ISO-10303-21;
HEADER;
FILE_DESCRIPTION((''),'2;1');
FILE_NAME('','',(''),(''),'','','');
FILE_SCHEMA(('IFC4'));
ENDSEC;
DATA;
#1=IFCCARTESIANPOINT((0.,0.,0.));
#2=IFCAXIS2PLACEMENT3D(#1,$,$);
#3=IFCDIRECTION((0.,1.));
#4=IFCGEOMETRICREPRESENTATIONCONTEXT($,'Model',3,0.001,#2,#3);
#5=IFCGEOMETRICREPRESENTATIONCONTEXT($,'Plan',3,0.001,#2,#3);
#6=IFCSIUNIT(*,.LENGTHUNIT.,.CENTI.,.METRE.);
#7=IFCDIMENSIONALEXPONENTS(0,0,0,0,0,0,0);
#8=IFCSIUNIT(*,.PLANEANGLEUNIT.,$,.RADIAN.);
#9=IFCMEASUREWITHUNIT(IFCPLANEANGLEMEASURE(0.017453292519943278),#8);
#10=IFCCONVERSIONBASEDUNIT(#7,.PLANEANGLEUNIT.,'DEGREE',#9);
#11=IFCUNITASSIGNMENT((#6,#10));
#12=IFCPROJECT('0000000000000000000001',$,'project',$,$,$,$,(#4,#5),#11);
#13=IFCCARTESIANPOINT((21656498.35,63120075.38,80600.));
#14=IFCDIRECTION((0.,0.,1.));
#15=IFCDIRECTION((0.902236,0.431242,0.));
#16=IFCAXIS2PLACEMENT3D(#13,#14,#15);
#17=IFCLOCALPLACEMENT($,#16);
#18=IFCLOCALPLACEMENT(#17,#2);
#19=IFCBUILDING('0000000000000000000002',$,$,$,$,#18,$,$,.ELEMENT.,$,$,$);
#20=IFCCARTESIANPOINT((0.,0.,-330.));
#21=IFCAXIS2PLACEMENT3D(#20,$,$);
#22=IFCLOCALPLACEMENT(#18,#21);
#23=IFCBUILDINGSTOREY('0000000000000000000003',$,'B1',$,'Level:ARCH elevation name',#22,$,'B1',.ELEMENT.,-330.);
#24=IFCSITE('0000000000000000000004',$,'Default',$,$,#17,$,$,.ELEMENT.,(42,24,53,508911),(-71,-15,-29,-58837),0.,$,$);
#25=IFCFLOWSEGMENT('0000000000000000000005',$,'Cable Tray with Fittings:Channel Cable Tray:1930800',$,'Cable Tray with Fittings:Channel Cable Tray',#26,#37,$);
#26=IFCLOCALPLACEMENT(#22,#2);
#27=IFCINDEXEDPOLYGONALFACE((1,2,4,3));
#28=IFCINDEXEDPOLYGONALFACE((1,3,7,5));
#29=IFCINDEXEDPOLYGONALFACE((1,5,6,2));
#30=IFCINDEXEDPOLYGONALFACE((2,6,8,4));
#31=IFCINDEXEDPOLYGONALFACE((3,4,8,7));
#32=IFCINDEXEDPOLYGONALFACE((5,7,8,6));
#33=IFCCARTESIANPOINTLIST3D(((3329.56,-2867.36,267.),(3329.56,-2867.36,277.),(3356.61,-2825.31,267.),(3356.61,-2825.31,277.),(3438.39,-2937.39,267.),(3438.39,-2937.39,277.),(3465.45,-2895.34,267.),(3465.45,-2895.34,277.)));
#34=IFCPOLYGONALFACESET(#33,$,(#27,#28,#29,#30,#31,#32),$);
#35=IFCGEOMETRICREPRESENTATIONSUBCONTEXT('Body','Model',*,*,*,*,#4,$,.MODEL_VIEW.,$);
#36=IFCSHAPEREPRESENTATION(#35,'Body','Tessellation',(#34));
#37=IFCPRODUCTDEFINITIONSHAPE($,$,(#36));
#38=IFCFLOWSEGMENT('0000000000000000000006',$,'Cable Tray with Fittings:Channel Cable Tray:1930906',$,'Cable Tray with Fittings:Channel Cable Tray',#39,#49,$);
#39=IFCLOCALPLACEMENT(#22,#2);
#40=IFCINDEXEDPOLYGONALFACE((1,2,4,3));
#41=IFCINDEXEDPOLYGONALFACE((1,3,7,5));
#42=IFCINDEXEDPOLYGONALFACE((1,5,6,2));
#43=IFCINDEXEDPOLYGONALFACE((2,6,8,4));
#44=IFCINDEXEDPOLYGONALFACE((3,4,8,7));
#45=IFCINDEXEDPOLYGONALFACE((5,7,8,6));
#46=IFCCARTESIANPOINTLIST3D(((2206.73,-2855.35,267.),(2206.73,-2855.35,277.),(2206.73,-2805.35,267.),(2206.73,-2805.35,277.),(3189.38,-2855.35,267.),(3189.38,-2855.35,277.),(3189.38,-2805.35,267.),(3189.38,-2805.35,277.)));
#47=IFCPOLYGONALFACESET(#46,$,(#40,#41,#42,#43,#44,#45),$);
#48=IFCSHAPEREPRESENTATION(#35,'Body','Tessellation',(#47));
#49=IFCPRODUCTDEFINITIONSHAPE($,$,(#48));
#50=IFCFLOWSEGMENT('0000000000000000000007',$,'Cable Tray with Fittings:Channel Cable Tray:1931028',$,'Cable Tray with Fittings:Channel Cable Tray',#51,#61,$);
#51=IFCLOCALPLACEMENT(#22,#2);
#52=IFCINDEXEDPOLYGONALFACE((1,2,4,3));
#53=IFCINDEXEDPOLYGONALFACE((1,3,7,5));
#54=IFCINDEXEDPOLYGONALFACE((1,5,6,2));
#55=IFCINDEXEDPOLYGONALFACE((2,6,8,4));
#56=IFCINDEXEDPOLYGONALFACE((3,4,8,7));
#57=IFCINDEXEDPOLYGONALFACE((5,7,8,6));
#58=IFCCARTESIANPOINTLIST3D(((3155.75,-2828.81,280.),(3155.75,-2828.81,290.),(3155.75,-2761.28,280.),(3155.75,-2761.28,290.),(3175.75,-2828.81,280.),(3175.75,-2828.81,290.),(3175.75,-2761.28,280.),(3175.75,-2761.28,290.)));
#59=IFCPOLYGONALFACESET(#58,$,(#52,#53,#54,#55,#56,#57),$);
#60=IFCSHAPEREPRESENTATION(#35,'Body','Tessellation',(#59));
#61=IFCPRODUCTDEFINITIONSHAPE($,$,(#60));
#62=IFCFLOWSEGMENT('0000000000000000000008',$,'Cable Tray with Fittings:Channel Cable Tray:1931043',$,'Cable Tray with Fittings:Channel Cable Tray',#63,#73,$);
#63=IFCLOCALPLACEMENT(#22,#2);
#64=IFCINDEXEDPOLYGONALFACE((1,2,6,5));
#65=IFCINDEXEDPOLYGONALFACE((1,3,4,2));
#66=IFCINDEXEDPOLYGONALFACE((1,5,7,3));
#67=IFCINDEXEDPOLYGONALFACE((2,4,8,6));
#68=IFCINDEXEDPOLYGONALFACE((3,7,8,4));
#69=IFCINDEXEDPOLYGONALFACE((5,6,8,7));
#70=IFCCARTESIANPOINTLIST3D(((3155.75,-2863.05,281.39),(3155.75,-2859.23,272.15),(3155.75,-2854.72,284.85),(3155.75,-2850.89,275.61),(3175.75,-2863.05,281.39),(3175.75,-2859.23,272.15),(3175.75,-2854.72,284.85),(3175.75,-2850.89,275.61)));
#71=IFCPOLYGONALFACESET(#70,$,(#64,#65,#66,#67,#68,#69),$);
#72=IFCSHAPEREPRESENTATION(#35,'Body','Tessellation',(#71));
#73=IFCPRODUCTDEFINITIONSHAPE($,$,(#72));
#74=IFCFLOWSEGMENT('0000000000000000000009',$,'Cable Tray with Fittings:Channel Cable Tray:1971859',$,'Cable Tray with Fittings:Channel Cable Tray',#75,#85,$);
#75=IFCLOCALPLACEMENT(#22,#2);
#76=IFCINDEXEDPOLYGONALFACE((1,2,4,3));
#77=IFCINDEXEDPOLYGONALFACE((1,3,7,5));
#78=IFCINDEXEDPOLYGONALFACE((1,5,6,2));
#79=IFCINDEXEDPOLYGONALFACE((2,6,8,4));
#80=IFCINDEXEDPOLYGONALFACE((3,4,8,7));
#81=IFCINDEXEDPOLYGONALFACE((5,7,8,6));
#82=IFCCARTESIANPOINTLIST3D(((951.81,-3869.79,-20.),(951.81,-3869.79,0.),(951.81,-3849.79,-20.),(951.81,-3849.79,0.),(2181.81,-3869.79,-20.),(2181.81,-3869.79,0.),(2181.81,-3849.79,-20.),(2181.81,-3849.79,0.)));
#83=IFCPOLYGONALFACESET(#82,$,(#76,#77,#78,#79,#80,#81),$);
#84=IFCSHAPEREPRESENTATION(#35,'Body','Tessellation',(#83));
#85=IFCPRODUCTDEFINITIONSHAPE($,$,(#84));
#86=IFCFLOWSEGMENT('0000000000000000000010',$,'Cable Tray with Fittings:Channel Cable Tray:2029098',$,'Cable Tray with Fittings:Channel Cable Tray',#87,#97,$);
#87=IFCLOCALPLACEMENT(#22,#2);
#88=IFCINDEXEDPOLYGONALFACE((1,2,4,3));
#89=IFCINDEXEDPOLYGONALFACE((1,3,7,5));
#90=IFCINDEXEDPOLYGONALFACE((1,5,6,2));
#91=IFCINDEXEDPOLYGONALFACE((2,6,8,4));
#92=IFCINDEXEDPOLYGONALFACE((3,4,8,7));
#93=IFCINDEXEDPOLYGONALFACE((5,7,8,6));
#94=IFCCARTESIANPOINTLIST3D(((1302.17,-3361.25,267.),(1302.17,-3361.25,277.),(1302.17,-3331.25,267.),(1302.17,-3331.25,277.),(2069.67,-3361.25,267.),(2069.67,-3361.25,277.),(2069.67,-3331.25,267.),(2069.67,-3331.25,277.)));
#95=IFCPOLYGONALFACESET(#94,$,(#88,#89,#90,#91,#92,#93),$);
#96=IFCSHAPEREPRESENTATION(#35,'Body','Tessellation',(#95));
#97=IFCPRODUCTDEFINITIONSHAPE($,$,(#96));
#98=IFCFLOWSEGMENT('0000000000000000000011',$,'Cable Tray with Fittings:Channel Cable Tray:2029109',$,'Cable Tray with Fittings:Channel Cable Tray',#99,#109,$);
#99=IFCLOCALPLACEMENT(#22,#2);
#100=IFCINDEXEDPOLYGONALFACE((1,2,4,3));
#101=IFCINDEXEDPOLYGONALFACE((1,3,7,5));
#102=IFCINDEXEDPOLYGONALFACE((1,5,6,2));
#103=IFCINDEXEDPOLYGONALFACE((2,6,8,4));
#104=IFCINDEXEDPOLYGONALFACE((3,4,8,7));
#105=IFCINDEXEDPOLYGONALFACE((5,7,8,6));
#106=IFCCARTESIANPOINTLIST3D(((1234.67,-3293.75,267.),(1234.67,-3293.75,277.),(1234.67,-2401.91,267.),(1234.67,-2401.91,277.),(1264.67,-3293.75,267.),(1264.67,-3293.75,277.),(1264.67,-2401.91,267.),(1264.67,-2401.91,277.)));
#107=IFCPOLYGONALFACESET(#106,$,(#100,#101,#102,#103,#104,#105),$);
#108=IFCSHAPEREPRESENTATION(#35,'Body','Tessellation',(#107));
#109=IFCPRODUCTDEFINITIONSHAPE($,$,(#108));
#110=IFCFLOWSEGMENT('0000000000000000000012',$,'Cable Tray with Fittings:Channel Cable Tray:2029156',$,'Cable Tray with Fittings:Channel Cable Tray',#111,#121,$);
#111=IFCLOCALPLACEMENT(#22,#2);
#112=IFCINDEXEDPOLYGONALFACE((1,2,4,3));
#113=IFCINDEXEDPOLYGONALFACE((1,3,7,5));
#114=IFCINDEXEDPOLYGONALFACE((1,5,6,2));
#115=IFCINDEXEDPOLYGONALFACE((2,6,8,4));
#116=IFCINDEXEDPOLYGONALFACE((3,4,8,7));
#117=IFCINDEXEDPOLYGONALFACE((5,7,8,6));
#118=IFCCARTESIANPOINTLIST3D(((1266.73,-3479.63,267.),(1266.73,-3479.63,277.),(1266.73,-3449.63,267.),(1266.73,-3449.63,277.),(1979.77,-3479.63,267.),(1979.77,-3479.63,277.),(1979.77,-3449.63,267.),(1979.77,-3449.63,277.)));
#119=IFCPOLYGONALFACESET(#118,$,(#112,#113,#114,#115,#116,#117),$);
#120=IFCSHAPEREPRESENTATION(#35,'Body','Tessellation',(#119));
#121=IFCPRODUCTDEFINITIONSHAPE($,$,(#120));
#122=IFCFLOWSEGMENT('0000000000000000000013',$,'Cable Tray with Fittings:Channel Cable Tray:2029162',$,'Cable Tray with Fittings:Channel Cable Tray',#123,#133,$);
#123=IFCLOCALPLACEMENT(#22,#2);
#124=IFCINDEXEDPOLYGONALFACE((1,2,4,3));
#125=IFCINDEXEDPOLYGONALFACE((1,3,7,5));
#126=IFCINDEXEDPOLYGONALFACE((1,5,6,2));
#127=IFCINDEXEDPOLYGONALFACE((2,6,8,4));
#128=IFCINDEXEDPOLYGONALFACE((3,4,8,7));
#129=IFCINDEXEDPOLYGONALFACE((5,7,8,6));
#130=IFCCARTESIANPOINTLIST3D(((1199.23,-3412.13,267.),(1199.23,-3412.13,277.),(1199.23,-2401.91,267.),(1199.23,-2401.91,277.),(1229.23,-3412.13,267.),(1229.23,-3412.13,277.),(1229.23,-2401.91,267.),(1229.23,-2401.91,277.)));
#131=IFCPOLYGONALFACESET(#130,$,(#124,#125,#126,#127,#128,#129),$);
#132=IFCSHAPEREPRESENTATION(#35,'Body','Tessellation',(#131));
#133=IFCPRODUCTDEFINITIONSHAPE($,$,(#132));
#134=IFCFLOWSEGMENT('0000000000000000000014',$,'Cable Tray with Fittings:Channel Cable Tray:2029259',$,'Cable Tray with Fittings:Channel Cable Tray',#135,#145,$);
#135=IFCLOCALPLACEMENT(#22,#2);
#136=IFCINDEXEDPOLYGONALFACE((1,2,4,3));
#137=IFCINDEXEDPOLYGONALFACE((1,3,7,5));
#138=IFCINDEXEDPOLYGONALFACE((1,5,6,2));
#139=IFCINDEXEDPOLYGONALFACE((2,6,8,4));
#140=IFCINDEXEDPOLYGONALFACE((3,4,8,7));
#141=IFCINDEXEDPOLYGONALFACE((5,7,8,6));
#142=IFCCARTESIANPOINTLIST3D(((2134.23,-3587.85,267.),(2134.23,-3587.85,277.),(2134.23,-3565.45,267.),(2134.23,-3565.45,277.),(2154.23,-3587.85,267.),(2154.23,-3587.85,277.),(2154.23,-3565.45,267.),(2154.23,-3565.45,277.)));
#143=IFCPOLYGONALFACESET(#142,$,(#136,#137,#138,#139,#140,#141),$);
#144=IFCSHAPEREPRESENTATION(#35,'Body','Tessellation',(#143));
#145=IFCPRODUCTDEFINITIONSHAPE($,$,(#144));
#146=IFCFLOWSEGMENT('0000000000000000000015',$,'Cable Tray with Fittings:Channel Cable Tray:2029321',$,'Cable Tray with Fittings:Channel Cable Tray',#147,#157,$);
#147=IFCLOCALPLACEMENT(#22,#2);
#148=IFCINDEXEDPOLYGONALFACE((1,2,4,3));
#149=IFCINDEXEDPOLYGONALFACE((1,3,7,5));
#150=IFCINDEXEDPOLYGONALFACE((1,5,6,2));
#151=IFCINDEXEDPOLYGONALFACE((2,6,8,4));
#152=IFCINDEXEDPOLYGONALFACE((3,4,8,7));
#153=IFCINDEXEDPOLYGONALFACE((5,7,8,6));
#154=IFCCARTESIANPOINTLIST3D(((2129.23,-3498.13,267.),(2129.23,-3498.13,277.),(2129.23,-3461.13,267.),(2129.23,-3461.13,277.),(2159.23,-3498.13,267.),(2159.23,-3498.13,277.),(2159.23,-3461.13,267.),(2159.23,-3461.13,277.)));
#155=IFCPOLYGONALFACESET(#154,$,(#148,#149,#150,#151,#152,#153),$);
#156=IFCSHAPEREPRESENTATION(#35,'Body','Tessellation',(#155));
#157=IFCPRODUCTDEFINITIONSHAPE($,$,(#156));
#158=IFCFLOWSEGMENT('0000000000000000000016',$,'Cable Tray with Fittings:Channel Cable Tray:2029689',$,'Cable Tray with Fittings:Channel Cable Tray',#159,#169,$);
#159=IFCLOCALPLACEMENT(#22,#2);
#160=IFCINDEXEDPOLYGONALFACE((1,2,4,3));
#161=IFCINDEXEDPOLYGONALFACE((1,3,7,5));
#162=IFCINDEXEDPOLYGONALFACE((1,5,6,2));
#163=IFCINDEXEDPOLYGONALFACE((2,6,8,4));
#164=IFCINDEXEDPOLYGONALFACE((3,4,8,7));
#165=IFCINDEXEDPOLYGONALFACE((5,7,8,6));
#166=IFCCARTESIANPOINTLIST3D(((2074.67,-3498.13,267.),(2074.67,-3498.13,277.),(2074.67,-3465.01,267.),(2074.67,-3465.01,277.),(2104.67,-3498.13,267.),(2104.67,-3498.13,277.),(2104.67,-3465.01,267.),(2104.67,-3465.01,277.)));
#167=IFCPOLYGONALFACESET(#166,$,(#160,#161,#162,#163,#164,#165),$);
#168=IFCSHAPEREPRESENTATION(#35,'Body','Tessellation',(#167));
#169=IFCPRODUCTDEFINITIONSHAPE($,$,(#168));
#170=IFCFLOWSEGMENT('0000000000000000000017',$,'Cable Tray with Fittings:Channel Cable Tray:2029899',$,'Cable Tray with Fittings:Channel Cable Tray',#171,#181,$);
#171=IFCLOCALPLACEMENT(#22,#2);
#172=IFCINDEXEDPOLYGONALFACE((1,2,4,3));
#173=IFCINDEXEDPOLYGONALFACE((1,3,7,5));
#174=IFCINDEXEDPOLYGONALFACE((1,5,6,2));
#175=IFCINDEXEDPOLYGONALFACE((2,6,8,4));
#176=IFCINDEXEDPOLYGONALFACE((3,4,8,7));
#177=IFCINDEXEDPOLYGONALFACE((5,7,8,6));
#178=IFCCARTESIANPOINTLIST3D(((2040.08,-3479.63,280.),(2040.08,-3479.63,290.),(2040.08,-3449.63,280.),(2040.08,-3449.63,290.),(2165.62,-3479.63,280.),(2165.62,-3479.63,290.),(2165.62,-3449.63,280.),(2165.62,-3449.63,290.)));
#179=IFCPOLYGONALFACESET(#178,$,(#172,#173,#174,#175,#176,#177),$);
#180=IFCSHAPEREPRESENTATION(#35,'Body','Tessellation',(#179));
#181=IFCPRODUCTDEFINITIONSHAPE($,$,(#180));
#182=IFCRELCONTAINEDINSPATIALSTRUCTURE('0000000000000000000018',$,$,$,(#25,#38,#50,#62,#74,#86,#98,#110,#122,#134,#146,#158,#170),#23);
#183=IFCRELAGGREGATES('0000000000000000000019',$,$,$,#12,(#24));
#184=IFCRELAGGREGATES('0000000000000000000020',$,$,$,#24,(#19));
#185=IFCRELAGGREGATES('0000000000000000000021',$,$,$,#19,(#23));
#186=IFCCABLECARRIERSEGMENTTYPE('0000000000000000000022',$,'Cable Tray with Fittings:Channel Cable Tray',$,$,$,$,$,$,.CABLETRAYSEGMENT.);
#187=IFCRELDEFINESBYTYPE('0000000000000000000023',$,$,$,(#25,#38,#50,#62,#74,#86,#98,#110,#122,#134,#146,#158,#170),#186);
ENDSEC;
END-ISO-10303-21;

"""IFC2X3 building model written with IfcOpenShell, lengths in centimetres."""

from ifc_helpers import new_model, entity, si_unit, converted_unit, direction, frame, frame_2d, origin, origin_2d_with_axis, place, context, subcontext, project, spatial, rectangle, extrude, type_object, element, save


model = new_model("IFC2X3")

# Units and contexts
model_context = context("Model", 3, precision=0.001, world=origin(), true_north=direction((0.0, 1.0)))
plan_context = context("Plan", 3, precision=0.001, world=origin(), true_north=direction((0.0, 1.0)))
body_context = subcontext(model_context, "Body", "Model", "MODEL_VIEW")
ifc_project = project(units=[si_unit("LENGTHUNIT", "METRE", prefix="CENTI"), converted_unit("PLANEANGLEUNIT", "DEGREE", entity("IfcPlaneAngleMeasure", 0.017453292519943278), si_unit("PLANEANGLEUNIT", "RADIAN"), dimensions=[0, 0, 0, 0, 0, 0, 0])], contexts=[model_context, plan_context])

# Site, building, storey
site_placement = place(None, frame((21656498.35, 63120075.38, 80600.0), z_axis=(0.0, 0.0, 1.0), x_axis=(0.902236, 0.431242, 0.0)))
site = spatial("IfcSite", under=ifc_project, at=site_placement, Name="Default", CompositionType="ELEMENT", RefLatitude=(42, 24, 53, 508911), RefLongitude=(-71, -15, -29, -58837), RefElevation=0.0)
building_placement = place(site_placement, origin())
building = spatial("IfcBuilding", under=site, at=building_placement, CompositionType="ELEMENT")
storey_placement = place(building_placement, frame((0.0, 0.0, -330.0)))
storey = spatial("IfcBuildingStorey", under=building, at=storey_placement, Name="B1", ObjectType="Level:ARCH elevation name", LongName="B1", CompositionType="ELEMENT", Elevation=-330.0)

# Flow segments
cable_carrier_segment_type = type_object("IfcCableCarrierSegmentType", Name="Cable Tray with Fittings:Channel Cable Tray", PredefinedType="CABLETRAYSEGMENT")
flow_segment_1_placement = place(storey_placement, origin())
element("IfcFlowSegment", 1, at=flow_segment_1_placement, inside=storey, type_object=cable_carrier_segment_type, Name="Cable Tray with Fittings:Channel Cable Tray:1930800", ObjectType="Cable Tray with Fittings:Channel Cable Tray", context=body_context, shape_type="SweptSolid", body=[
    extrude(rectangle(XDim=129.42, YDim=50.0, at=frame_2d((0.0, 0.0), x_axis=(1.0, 0.0))), frame((3397.5, -2881.35, 267.0), z_axis=(0.0, 0.0, 1.0), x_axis=(-0.840959, 0.541099, 0.0)), (0.0, 0.0, 1.0), 10.0),
])
flow_segment_2_placement = place(storey_placement, origin())
element("IfcFlowSegment", 2, at=flow_segment_2_placement, inside=storey, type_object=cable_carrier_segment_type, Name="Cable Tray with Fittings:Channel Cable Tray:1930906", ObjectType="Cable Tray with Fittings:Channel Cable Tray", context=body_context, shape_type="SweptSolid", body=[
    extrude(rectangle(XDim=982.65, YDim=50.0, at=frame_2d((0.0, 0.0), x_axis=(1.0, 0.0))), frame((2698.06, -2830.35, 267.0), z_axis=(0.0, 0.0, 1.0), x_axis=(-1.0, 0.0, 0.0)), (0.0, 0.0, 1.0), 10.0),
])
flow_segment_3_placement = place(storey_placement, origin())
element("IfcFlowSegment", 3, at=flow_segment_3_placement, inside=storey, type_object=cable_carrier_segment_type, Name="Cable Tray with Fittings:Channel Cable Tray:1931028", ObjectType="Cable Tray with Fittings:Channel Cable Tray", context=body_context, shape_type="SweptSolid", body=[
    extrude(rectangle(XDim=67.53, YDim=20.0, at=frame_2d((0.0, 0.0), x_axis=(1.0, 0.0))), frame((3165.75, -2795.04, 280.0), z_axis=(0.0, 0.0, 1.0), x_axis=(0.0, 1.0, 0.0)), (0.0, 0.0, 1.0), 10.0),
])
flow_segment_4_placement = place(storey_placement, origin())
element("IfcFlowSegment", 4, at=flow_segment_4_placement, inside=storey, type_object=cable_carrier_segment_type, Name="Cable Tray with Fittings:Channel Cable Tray:1931043", ObjectType="Cable Tray with Fittings:Channel Cable Tray", context=body_context, shape_type="SweptSolid", body=[
    extrude(rectangle(XDim=10.0, YDim=9.03, at=frame_2d((0.0, 0.0), x_axis=(0.0, 1.0))), frame((3155.75, -2856.97, 278.5), z_axis=(1.0, 0.0, 0.0), x_axis=(0.0, 0.92388, 0.382683)), (0.0, 0.0, 1.0), 20.0),
])
flow_segment_5_placement = place(storey_placement, origin())
element("IfcFlowSegment", 5, at=flow_segment_5_placement, inside=storey, type_object=cable_carrier_segment_type, Name="Cable Tray with Fittings:Channel Cable Tray:1971859", ObjectType="Cable Tray with Fittings:Channel Cable Tray", context=body_context, shape_type="SweptSolid", body=[
    extrude(rectangle(XDim=1230.0, YDim=20.0, at=frame_2d((0.0, 0.0), x_axis=(1.0, 0.0))), frame((1566.81, -3859.79, -20.0)), (0.0, 0.0, 1.0), 20.0),
])
flow_segment_6_placement = place(storey_placement, origin())
element("IfcFlowSegment", 6, at=flow_segment_6_placement, inside=storey, type_object=cable_carrier_segment_type, Name="Cable Tray with Fittings:Channel Cable Tray:2029098", ObjectType="Cable Tray with Fittings:Channel Cable Tray", context=body_context, shape_type="SweptSolid", body=[
    extrude(rectangle(XDim=767.5, YDim=30.0, at=frame_2d((0.0, 0.0), x_axis=(1.0, 0.0))), frame((1685.92, -3346.25, 267.0)), (0.0, 0.0, 1.0), 10.0),
])
flow_segment_7_placement = place(storey_placement, origin())
element("IfcFlowSegment", 7, at=flow_segment_7_placement, inside=storey, type_object=cable_carrier_segment_type, Name="Cable Tray with Fittings:Channel Cable Tray:2029109", ObjectType="Cable Tray with Fittings:Channel Cable Tray", context=body_context, shape_type="SweptSolid", body=[
    extrude(rectangle(XDim=891.84, YDim=30.0, at=frame_2d((0.0, 0.0), x_axis=(1.0, 0.0))), frame((1249.67, -2847.83, 267.0), z_axis=(0.0, 0.0, 1.0), x_axis=(0.0, 1.0, 0.0)), (0.0, 0.0, 1.0), 10.0),
])
flow_segment_8_placement = place(storey_placement, origin())
element("IfcFlowSegment", 8, at=flow_segment_8_placement, inside=storey, type_object=cable_carrier_segment_type, Name="Cable Tray with Fittings:Channel Cable Tray:2029156", ObjectType="Cable Tray with Fittings:Channel Cable Tray", context=body_context, shape_type="SweptSolid", body=[
    extrude(rectangle(XDim=713.04, YDim=30.0, at=frame_2d((0.0, 0.0), x_axis=(1.0, 0.0))), frame((1623.25, -3464.63, 267.0)), (0.0, 0.0, 1.0), 10.0),
])
flow_segment_9_placement = place(storey_placement, origin())
element("IfcFlowSegment", 9, at=flow_segment_9_placement, inside=storey, type_object=cable_carrier_segment_type, Name="Cable Tray with Fittings:Channel Cable Tray:2029162", ObjectType="Cable Tray with Fittings:Channel Cable Tray", context=body_context, shape_type="SweptSolid", body=[
    extrude(rectangle(XDim=1010.22, YDim=30.0, at=origin_2d_with_axis()), frame((1214.23, -2907.02, 267.0), z_axis=(0.0, 0.0, 1.0), x_axis=(0.0, 1.0, 0.0)), (0.0, 0.0, 1.0), 10.0),
])
flow_segment_10_placement = place(storey_placement, origin())
element("IfcFlowSegment", 10, at=flow_segment_10_placement, inside=storey, type_object=cable_carrier_segment_type, Name="Cable Tray with Fittings:Channel Cable Tray:2029259", ObjectType="Cable Tray with Fittings:Channel Cable Tray", context=body_context, shape_type="SweptSolid", body=[
    extrude(rectangle(XDim=22.4, YDim=20.0, at=frame_2d((0.0, 0.0), x_axis=(1.0, 0.0))), frame((2144.23, -3576.65, 267.0), z_axis=(0.0, 0.0, 1.0), x_axis=(0.0, 1.0, 0.0)), (0.0, 0.0, 1.0), 10.0),
])
flow_segment_11_placement = place(storey_placement, origin())
element("IfcFlowSegment", 11, at=flow_segment_11_placement, inside=storey, type_object=cable_carrier_segment_type, Name="Cable Tray with Fittings:Channel Cable Tray:2029321", ObjectType="Cable Tray with Fittings:Channel Cable Tray", context=body_context, shape_type="SweptSolid", body=[
    extrude(rectangle(XDim=37.0, YDim=30.0, at=frame_2d((0.0, 0.0), x_axis=(1.0, 0.0))), frame((2144.23, -3479.63, 267.0), z_axis=(0.0, 0.0, 1.0), x_axis=(0.0, -1.0, 0.0)), (0.0, 0.0, 1.0), 10.0),
])
flow_segment_12_placement = place(storey_placement, origin())
element("IfcFlowSegment", 12, at=flow_segment_12_placement, inside=storey, type_object=cable_carrier_segment_type, Name="Cable Tray with Fittings:Channel Cable Tray:2029689", ObjectType="Cable Tray with Fittings:Channel Cable Tray", context=body_context, shape_type="SweptSolid", body=[
    extrude(rectangle(XDim=33.12, YDim=30.0, at=frame_2d((0.0, 0.0), x_axis=(1.0, 0.0))), frame((2089.67, -3481.57, 267.0), z_axis=(0.0, 0.0, 1.0), x_axis=(0.0, -1.0, 0.0)), (0.0, 0.0, 1.0), 10.0),
])
flow_segment_13_placement = place(storey_placement, origin())
element("IfcFlowSegment", 13, at=flow_segment_13_placement, inside=storey, type_object=cable_carrier_segment_type, Name="Cable Tray with Fittings:Channel Cable Tray:2029899", ObjectType="Cable Tray with Fittings:Channel Cable Tray", context=body_context, shape_type="SweptSolid", body=[
    extrude(rectangle(XDim=125.54, YDim=30.0, at=origin_2d_with_axis()), frame((2102.85, -3464.63, 280.0)), (0.0, 0.0, 1.0), 10.0),
])

save(model, "model.ifc")
